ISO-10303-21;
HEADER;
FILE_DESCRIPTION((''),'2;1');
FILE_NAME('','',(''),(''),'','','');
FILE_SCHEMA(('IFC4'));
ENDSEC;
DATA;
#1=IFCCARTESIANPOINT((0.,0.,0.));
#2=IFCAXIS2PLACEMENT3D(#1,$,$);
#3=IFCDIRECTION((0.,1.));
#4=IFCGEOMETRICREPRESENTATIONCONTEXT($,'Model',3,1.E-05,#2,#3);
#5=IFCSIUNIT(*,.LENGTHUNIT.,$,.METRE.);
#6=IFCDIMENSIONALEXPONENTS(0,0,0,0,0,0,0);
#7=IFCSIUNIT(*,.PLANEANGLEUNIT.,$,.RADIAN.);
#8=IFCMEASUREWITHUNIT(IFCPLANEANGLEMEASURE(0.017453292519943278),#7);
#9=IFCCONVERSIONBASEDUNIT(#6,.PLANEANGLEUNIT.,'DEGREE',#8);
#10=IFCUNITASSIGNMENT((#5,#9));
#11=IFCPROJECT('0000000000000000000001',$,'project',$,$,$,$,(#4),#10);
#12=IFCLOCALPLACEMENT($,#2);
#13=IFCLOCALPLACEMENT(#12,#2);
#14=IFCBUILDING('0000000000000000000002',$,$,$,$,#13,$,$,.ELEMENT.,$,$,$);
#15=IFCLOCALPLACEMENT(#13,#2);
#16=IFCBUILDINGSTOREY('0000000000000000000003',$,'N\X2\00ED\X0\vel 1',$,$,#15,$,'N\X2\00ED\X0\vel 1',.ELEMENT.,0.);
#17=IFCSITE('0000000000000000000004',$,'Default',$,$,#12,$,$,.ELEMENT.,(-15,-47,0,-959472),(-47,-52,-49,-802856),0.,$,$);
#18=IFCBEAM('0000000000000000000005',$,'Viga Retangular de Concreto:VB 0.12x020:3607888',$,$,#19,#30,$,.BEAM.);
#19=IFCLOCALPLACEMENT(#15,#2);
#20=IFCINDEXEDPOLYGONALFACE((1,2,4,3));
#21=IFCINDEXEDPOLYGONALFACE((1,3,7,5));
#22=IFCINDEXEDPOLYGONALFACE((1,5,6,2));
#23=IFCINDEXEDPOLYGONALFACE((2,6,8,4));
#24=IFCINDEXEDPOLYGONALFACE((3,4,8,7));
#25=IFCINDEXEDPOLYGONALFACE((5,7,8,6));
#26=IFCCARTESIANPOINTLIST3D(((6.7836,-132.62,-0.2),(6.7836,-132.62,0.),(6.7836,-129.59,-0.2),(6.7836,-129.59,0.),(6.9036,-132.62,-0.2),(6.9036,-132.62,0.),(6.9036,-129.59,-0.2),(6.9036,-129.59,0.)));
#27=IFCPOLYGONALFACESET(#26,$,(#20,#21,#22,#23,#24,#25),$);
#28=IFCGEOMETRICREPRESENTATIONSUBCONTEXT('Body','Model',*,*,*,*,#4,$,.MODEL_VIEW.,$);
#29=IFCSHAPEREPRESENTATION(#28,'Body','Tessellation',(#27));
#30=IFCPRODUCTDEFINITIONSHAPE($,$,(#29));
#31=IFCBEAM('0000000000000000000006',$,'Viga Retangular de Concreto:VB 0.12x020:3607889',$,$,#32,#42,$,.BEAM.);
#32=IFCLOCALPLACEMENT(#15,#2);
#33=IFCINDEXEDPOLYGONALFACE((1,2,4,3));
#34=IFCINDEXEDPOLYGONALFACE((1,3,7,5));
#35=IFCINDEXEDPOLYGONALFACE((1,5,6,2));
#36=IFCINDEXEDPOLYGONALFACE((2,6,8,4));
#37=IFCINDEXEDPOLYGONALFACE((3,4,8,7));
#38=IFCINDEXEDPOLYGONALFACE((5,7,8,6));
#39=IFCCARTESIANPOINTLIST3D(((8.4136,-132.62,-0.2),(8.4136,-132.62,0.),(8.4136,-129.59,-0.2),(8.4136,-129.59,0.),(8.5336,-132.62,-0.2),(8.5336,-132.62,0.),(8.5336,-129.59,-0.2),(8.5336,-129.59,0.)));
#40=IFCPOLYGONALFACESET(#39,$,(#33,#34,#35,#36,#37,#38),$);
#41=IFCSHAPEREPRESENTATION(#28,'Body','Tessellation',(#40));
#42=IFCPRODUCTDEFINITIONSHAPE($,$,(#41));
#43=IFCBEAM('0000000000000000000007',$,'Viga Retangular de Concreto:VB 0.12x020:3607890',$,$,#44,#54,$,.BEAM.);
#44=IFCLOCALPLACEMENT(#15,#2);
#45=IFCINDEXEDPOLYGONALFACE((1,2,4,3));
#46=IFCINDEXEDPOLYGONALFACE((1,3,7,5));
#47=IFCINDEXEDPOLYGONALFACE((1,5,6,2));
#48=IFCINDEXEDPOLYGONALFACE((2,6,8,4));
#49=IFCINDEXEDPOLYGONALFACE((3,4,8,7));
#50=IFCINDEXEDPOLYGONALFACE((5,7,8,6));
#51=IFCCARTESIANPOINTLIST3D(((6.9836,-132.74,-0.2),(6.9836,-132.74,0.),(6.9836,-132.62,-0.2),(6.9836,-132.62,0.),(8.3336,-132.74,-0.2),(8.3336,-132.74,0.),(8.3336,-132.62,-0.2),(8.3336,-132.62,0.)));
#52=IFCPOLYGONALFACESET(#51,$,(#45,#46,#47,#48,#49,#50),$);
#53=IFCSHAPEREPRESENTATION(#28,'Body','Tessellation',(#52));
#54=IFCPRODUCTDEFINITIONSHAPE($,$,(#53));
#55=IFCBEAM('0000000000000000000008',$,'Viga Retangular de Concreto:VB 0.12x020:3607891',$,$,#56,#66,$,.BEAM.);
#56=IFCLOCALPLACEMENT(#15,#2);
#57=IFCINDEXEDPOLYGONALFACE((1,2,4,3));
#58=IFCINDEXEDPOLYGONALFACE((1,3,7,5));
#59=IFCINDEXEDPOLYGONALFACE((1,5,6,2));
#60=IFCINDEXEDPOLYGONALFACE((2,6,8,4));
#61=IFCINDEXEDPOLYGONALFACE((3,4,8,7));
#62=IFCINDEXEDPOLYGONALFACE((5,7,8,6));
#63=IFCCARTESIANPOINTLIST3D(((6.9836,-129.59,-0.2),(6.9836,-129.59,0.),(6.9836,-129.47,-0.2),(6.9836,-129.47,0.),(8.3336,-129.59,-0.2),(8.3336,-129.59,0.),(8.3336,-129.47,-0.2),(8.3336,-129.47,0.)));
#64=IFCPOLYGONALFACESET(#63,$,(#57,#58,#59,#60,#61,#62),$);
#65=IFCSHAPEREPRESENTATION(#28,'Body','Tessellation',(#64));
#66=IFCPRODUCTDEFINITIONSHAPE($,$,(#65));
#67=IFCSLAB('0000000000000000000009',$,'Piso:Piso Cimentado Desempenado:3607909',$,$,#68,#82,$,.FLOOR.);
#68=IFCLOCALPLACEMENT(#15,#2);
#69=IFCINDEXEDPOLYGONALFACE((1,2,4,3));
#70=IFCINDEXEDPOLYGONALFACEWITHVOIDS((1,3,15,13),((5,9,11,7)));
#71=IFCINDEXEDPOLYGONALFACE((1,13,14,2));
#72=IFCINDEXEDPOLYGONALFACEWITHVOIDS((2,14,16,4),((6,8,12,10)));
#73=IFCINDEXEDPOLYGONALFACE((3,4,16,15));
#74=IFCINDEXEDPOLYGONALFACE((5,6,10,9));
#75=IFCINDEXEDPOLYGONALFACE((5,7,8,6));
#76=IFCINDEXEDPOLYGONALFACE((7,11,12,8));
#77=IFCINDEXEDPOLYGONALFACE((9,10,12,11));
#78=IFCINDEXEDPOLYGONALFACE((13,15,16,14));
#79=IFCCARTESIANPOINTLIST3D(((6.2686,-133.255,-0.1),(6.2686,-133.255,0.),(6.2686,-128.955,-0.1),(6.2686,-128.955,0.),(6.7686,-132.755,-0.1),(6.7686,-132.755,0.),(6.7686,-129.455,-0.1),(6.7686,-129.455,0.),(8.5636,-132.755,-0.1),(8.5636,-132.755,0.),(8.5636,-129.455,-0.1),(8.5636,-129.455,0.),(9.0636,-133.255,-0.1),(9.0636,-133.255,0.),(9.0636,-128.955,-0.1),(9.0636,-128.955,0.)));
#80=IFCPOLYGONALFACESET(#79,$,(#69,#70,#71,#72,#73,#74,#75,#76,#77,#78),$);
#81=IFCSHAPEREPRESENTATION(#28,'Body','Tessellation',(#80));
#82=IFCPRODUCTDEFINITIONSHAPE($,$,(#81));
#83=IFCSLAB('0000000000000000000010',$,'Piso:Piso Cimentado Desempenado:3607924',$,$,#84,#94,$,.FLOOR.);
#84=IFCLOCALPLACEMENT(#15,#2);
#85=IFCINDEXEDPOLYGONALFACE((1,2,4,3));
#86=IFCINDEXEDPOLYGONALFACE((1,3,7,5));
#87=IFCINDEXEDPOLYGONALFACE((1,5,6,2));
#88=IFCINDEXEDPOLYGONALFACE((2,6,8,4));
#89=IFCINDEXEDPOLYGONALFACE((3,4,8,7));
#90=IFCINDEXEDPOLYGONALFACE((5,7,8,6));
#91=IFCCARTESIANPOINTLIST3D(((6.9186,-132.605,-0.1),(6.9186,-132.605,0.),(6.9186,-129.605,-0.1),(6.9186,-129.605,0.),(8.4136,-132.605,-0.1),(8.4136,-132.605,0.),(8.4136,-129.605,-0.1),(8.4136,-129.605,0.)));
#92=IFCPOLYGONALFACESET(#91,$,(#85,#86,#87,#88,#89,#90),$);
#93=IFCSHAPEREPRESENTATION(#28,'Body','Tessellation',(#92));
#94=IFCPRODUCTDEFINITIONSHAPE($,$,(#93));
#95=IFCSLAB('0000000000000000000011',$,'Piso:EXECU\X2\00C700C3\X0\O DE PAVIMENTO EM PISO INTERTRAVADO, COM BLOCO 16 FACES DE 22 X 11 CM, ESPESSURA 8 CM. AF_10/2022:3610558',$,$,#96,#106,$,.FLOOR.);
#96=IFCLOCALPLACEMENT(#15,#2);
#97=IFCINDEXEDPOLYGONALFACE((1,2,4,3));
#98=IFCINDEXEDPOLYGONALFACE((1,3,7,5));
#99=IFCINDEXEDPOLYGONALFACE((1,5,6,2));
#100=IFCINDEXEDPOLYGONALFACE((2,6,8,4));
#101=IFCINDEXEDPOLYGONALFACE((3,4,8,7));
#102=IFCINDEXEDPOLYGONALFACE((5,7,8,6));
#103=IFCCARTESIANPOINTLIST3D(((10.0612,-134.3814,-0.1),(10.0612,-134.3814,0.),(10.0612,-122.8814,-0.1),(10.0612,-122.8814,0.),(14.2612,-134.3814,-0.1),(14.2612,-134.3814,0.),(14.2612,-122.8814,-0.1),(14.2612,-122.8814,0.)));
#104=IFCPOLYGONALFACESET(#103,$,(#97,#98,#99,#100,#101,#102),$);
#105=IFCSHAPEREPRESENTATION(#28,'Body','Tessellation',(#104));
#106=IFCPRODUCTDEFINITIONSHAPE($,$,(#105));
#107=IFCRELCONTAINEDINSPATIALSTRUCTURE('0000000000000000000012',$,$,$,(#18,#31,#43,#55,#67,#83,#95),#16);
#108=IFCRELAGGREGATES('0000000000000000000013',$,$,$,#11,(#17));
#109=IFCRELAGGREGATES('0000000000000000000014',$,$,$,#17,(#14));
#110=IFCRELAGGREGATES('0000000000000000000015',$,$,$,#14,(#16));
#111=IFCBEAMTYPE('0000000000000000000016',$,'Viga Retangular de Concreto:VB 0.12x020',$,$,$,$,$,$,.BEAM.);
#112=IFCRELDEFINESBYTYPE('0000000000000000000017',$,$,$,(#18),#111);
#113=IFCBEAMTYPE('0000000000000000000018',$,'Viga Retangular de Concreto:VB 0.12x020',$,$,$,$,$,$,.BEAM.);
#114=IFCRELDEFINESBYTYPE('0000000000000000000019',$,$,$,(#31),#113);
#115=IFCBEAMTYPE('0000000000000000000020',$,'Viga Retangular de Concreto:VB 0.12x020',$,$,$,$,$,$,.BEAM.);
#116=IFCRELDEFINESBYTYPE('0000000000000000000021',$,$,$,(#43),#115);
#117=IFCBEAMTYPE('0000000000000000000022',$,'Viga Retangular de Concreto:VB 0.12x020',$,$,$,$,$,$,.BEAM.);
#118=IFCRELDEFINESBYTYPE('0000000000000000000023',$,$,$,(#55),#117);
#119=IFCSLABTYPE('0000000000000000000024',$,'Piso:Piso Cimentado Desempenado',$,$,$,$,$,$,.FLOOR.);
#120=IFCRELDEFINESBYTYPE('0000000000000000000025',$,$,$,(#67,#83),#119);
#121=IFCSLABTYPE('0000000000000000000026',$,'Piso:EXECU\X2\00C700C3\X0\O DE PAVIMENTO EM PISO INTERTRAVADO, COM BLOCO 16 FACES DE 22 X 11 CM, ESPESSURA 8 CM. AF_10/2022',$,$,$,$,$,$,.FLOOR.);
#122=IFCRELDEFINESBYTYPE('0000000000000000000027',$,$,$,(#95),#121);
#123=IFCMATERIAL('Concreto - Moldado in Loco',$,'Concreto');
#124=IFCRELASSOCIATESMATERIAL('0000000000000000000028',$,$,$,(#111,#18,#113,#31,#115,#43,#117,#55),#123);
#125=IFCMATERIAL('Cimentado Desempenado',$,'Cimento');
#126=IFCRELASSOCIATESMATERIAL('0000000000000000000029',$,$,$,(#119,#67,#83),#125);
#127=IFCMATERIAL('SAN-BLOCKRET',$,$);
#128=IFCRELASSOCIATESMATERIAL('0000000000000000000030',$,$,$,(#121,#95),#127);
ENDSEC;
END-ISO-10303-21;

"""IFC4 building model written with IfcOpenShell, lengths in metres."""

from ifc_helpers import new_model, entity, si_unit, converted_unit, direction, frame, origin, place, context, subcontext, project, spatial, indexed_curve, outline, extrude, source, transform, mapped, material, type_object, type_shapes, element, save


model = new_model("IFC4")

# Units and contexts
model_context = context("Model", 3, precision=1e-05, world=origin(), true_north=direction((0.0, 1.0)))
body_context = subcontext(model_context, "Body", "Model", "MODEL_VIEW")
ifc_project = project(units=[si_unit("LENGTHUNIT", "METRE"), converted_unit("PLANEANGLEUNIT", "DEGREE", entity("IfcPlaneAngleMeasure", 0.017453292519943278), si_unit("PLANEANGLEUNIT", "RADIAN"), dimensions=[0, 0, 0, 0, 0, 0, 0])], contexts=[model_context])

# Site, building, storey
site_placement = place(None, origin())
site = spatial("IfcSite", under=ifc_project, at=site_placement, Name="Default", CompositionType="ELEMENT", RefLatitude=(-15, -47, 0, -959472), RefLongitude=(-47, -52, -49, -802856), RefElevation=0.0)
building_placement = place(site_placement, origin())
building = spatial("IfcBuilding", under=site, at=building_placement, CompositionType="ELEMENT")
storey_placement = place(building_placement, origin())
storey = spatial("IfcBuildingStorey", under=building, at=storey_placement, Name="Nível 1", LongName="Nível 1", CompositionType="ELEMENT", Elevation=0.0)

# Beams
ifc_material_1 = material(Name="Concreto - Moldado in Loco", Category="Concreto")
beam_type_1 = type_object("IfcBeamType", Name="Viga Retangular de Concreto:VB 0.12x020", PredefinedType="BEAM", material=ifc_material_1)
shared_shape_1 = source(origin(), body_context, "Body", "SweptSolid", [
    extrude(outline(indexed_curve([(-0.06, -0.1), (0.06, -0.1), (0.06, 0.1), (-0.06, 0.1), (-0.06, -0.1)], self_intersect=False)), frame((6.8436, -132.62, -0.1), z_axis=(0.0, 1.0, 0.0), x_axis=(-1.0, 0.0, 0.0)), (0.0, 0.0, 1.0), 3.03),
])
type_shapes(beam_type_1, [shared_shape_1])
beam_1_placement = place(storey_placement, origin())
element("IfcBeam", 1, at=beam_1_placement, inside=storey, type_object=beam_type_1, material=ifc_material_1, Name="Viga Retangular de Concreto:VB 0.12x020:3607888", PredefinedType="BEAM", context=body_context, shape_type="MappedRepresentation", body=[
    mapped(shared_shape_1, transform((0.0, 0.0, 0.0), scale=1.0)),
])
beam_type_2 = type_object("IfcBeamType", Name="Viga Retangular de Concreto:VB 0.12x020", PredefinedType="BEAM", material=ifc_material_1)
shared_shape_2 = source(origin(), body_context, "Body", "SweptSolid", [
    extrude(outline(indexed_curve([(-0.06, -0.1), (0.06, -0.1), (0.06, 0.1), (-0.06, 0.1), (-0.06, -0.1)], self_intersect=False)), frame((8.4736, -132.62, -0.1), z_axis=(0.0, 1.0, 0.0), x_axis=(-1.0, 0.0, 0.0)), (0.0, 0.0, 1.0), 3.03),
])
type_shapes(beam_type_2, [shared_shape_2])
beam_2_placement = place(storey_placement, origin())
element("IfcBeam", 2, at=beam_2_placement, inside=storey, type_object=beam_type_2, material=ifc_material_1, Name="Viga Retangular de Concreto:VB 0.12x020:3607889", PredefinedType="BEAM", context=body_context, shape_type="MappedRepresentation", body=[
    mapped(shared_shape_2, transform((0.0, 0.0, 0.0), scale=1.0)),
])
beam_type_3 = type_object("IfcBeamType", Name="Viga Retangular de Concreto:VB 0.12x020", PredefinedType="BEAM", material=ifc_material_1)
shared_shape_3 = source(origin(), body_context, "Body", "SweptSolid", [
    extrude(outline(indexed_curve([(-0.1, -0.06), (0.1, -0.06), (0.1, 0.06), (-0.1, 0.06), (-0.1, -0.06)], self_intersect=False)), frame((8.3336, -132.68, -0.1), z_axis=(-1.0, 0.0, 0.0), x_axis=(0.0, 0.0, -1.0)), (0.0, 0.0, 1.0), 1.35),
])
type_shapes(beam_type_3, [shared_shape_3])
beam_3_placement = place(storey_placement, origin())
element("IfcBeam", 3, at=beam_3_placement, inside=storey, type_object=beam_type_3, material=ifc_material_1, Name="Viga Retangular de Concreto:VB 0.12x020:3607890", PredefinedType="BEAM", context=body_context, shape_type="MappedRepresentation", body=[
    mapped(shared_shape_3, transform((0.0, 0.0, 0.0), scale=1.0)),
])
beam_type_4 = type_object("IfcBeamType", Name="Viga Retangular de Concreto:VB 0.12x020", PredefinedType="BEAM", material=ifc_material_1)
shared_shape_4 = source(origin(), body_context, "Body", "SweptSolid", [
    extrude(outline(indexed_curve([(-0.1, -0.06), (0.1, -0.06), (0.1, 0.06), (-0.1, 0.06), (-0.1, -0.06)], self_intersect=False)), frame((8.3336, -129.53, -0.1), z_axis=(-1.0, 0.0, 0.0), x_axis=(0.0, 0.0, -1.0)), (0.0, 0.0, 1.0), 1.35),
])
type_shapes(beam_type_4, [shared_shape_4])
beam_4_placement = place(storey_placement, origin())
element("IfcBeam", 4, at=beam_4_placement, inside=storey, type_object=beam_type_4, material=ifc_material_1, Name="Viga Retangular de Concreto:VB 0.12x020:3607891", PredefinedType="BEAM", context=body_context, shape_type="MappedRepresentation", body=[
    mapped(shared_shape_4, transform((0.0, 0.0, 0.0), scale=1.0)),
])

# Slab, opening
ifc_material_2 = material(Name="Cimentado Desempenado", Category="Cimento")
slab_type_1 = type_object("IfcSlabType", Name="Piso:Piso Cimentado Desempenado", PredefinedType="FLOOR", material=ifc_material_2)
slab_1_placement = place(storey_placement, origin())
slab_1 = element("IfcSlab", 5, at=slab_1_placement, inside=storey, type_object=slab_type_1, material=ifc_material_2, Name="Piso:Piso Cimentado Desempenado:3607909", PredefinedType="FLOOR", context=body_context, shape_type="SweptSolid", body=[
    extrude(outline(indexed_curve([(-1.3975, -2.15), (1.3975, -2.15), (1.3975, 2.15), (-1.3975, 2.15), (-1.3975, -2.15)], self_intersect=False), holes=[indexed_curve([(0.8975, -1.65), (-0.8975, -1.65), (-0.8975, 1.65), (0.8975, 1.65), (0.8975, -1.65)], self_intersect=False)]), frame((7.6661, -131.105, -0.1)), (0.0, 0.0, 1.0), 0.1),
])
opening_1_placement = place(slab_1_placement, origin())
element("IfcOpeningElement", 6, at=opening_1_placement, cuts=slab_1, PredefinedType="OPENING", context=body_context, shape_type="SweptSolid", body=[
    extrude(outline(indexed_curve([(8.5636, -132.755), (8.5636, -129.455), (6.7686, -129.455), (6.7686, -132.755), (8.5636, -132.755)], self_intersect=False)), origin(), (0.0, 0.0, -1.0), 4.3),
])

# Slabs
slab_2_placement = place(storey_placement, origin())
element("IfcSlab", 7, at=slab_2_placement, inside=storey, type_object=slab_type_1, material=ifc_material_2, Name="Piso:Piso Cimentado Desempenado:3607924", PredefinedType="FLOOR", context=body_context, shape_type="SweptSolid", body=[
    extrude(outline(indexed_curve([(-1.5, -0.7475), (1.5, -0.7475), (1.5, 0.7475), (-1.5, 0.7475), (-1.5, -0.7475)], self_intersect=False)), frame((7.6661, -131.105, 0.0), z_axis=(0.0, 0.0, -1.0), x_axis=(0.0, 1.0, 0.0)), (0.0, 0.0, 1.0), 0.1),
])
ifc_material_3 = material(Name="SAN-BLOCKRET")
slab_type_2 = type_object("IfcSlabType", Name="Piso:EXECUÇÃO DE PAVIMENTO EM PISO INTERTRAVADO, COM BLOCO 16 FACES DE 22 X 11 CM, ESPESSURA 8 CM. AF_10/2022", PredefinedType="FLOOR", material=ifc_material_3)
slab_3_placement = place(storey_placement, origin())
element("IfcSlab", 8, at=slab_3_placement, inside=storey, type_object=slab_type_2, material=ifc_material_3, Name="Piso:EXECUÇÃO DE PAVIMENTO EM PISO INTERTRAVADO, COM BLOCO 16 FACES DE 22 X 11 CM, ESPESSURA 8 CM. AF_10/2022:3610558", PredefinedType="FLOOR", context=body_context, shape_type="SweptSolid", body=[
    extrude(outline(indexed_curve([(-5.75, -2.1), (5.75, -2.1), (5.75, 2.1), (-5.75, 2.1), (-5.75, -2.1)], self_intersect=False)), frame((12.1612, -128.6314, 0.0), z_axis=(0.0, 0.0, -1.0), x_axis=(0.0, 1.0, 0.0)), (0.0, 0.0, 1.0), 0.1),
])

save(model, "model.ifc")
